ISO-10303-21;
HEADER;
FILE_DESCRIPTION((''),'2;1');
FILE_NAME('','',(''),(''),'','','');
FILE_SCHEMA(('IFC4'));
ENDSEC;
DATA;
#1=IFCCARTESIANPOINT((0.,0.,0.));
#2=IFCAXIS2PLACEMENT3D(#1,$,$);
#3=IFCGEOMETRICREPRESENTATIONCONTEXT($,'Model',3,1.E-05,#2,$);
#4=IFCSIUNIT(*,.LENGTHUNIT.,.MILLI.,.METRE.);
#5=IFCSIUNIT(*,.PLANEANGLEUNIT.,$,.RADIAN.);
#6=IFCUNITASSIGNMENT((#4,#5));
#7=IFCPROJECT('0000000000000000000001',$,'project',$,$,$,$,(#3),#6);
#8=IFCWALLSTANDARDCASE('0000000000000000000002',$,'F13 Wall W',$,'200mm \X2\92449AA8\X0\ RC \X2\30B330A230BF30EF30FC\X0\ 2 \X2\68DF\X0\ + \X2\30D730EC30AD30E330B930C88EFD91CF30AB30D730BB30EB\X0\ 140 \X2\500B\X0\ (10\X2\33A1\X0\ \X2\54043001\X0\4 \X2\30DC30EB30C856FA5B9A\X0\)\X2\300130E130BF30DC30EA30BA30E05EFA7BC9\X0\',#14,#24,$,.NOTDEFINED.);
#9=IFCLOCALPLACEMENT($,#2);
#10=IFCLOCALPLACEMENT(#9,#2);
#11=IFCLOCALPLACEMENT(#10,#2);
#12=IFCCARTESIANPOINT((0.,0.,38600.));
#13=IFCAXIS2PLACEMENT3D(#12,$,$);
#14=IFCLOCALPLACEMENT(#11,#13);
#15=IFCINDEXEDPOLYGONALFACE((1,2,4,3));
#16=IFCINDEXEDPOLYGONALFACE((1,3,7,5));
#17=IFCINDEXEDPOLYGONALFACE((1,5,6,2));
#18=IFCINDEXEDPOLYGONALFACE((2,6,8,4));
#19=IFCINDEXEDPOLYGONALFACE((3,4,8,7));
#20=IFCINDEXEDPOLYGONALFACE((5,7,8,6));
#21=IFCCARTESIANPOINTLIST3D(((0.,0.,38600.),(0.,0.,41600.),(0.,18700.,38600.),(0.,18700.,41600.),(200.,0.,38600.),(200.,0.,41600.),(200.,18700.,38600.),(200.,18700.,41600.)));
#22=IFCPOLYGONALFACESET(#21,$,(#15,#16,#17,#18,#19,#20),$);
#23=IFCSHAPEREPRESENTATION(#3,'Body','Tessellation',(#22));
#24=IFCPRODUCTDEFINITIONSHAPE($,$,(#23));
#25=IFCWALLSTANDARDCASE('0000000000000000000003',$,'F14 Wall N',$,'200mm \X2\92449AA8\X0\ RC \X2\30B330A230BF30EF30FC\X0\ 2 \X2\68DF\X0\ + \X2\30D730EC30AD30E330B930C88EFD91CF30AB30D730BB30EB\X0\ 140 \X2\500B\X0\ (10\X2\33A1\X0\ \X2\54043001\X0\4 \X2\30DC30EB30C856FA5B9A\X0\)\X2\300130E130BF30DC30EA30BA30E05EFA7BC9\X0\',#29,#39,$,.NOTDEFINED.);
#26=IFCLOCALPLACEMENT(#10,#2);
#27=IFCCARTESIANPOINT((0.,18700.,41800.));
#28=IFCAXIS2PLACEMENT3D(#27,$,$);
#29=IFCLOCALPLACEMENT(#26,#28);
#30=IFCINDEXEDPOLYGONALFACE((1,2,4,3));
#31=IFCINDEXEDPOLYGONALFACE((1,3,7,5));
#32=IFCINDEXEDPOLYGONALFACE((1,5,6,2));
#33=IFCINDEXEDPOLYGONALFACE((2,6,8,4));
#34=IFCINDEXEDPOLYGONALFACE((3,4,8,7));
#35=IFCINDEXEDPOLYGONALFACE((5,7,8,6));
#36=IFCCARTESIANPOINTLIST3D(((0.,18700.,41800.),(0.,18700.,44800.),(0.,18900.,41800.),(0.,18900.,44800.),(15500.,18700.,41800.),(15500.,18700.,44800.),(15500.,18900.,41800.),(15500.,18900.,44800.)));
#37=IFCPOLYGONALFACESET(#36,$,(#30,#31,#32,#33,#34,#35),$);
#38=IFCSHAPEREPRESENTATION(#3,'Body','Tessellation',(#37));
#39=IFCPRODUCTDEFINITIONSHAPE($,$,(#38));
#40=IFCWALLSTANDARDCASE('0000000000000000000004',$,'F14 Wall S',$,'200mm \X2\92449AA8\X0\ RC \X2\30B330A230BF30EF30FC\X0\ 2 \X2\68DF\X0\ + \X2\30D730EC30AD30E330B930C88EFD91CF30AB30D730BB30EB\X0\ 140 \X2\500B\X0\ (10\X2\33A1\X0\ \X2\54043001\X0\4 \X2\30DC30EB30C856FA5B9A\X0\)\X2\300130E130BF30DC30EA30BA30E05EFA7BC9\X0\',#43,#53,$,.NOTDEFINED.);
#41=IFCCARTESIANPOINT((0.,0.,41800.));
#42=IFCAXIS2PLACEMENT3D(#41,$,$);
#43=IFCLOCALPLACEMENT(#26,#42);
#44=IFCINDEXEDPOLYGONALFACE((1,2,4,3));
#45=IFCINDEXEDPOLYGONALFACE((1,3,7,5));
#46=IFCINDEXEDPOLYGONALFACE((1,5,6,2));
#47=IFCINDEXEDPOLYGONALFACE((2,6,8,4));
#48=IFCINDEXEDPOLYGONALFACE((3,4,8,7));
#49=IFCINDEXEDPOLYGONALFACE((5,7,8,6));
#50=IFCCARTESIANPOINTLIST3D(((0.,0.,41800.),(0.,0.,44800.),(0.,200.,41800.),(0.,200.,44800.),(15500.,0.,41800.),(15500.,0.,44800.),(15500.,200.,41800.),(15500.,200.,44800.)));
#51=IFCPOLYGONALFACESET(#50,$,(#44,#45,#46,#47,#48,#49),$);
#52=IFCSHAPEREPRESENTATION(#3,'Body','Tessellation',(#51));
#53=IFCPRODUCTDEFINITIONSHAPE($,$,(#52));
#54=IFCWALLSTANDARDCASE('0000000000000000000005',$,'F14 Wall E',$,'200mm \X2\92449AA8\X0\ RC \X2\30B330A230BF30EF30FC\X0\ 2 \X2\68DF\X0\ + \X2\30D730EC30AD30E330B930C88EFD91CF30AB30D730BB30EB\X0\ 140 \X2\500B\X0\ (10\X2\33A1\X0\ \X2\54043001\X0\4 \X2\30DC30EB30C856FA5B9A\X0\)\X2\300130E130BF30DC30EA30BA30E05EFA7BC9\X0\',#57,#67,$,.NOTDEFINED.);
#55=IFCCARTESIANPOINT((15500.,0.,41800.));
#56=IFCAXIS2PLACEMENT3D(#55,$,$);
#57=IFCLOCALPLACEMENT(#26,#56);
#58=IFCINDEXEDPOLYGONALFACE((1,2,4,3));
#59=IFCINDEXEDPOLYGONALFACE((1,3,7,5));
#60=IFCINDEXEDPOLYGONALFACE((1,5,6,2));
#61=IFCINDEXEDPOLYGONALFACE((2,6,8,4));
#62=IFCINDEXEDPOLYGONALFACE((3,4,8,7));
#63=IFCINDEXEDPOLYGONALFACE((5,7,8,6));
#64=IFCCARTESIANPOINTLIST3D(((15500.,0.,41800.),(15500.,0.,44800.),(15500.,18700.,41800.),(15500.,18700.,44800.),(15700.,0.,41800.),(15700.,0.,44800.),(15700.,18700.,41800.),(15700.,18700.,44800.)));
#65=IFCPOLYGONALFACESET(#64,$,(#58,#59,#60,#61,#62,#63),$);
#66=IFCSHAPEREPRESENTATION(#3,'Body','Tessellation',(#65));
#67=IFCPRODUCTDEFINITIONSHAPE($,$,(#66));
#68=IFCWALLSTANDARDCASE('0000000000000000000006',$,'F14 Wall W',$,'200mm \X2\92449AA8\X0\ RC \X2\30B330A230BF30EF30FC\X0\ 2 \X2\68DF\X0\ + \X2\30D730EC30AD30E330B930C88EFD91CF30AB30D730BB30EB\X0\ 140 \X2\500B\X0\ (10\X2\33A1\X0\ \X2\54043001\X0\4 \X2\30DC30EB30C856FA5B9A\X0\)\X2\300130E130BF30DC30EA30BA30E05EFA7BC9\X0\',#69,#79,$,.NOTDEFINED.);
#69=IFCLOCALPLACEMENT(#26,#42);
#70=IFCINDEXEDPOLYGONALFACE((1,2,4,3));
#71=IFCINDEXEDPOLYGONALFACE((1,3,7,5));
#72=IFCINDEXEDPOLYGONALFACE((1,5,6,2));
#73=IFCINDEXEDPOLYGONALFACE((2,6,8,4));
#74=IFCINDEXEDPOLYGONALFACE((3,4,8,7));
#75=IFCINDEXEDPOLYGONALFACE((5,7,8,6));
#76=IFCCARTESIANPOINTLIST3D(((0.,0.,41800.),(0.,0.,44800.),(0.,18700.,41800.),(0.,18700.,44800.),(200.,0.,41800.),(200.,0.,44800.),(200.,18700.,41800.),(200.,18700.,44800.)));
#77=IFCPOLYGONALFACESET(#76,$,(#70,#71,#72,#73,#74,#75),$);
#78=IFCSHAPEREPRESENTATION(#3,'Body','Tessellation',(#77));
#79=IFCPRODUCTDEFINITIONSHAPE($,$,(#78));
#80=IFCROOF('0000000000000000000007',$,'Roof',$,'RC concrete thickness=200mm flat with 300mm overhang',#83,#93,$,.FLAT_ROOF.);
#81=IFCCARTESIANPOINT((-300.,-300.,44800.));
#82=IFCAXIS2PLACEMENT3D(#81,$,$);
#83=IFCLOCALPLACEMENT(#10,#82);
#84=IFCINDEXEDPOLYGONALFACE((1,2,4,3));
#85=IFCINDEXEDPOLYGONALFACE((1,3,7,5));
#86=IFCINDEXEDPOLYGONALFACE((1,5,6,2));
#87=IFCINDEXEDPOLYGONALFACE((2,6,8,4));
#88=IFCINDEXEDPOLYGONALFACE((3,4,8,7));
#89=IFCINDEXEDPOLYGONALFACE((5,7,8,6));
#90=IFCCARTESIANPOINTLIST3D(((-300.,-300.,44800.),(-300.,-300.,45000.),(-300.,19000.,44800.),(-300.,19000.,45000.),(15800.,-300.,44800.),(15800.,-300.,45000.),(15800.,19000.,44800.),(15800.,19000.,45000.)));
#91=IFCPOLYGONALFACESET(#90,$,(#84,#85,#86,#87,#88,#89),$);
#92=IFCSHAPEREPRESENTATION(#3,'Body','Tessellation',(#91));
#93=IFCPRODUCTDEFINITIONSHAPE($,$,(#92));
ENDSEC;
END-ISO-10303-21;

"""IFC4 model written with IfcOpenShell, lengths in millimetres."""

from ifc_helpers import new_model, si_unit, frame, frame_2d, origin, place, context, project, rectangle, extrude, element, save


model = new_model("IFC4")

# Units and contexts
model_context = context("Model", 3, precision=1e-05, world=origin())
ifc_project = project(units=[si_unit("LENGTHUNIT", "METRE", prefix="MILLI"), si_unit("PLANEANGLEUNIT", "RADIAN")], contexts=[model_context])

# Shared definitions
placement_1 = place(None, origin())
placement_2 = place(placement_1, origin())
placement_3 = place(placement_2, origin())
placement_4 = place(placement_2, origin())

# Walls
wall_1_placement = place(placement_3, frame((0.0, 0.0, 38600.0)))
element("IfcWallStandardCase", 1, at=wall_1_placement, Name="F13 Wall W", ObjectType="200mm 鉄骨 RC コアタワー 2 棟 + プレキャスト軽量カプセル 140 個 (10㎡ 各、4 ボルト固定)、メタボリズム建築", PredefinedType="NOTDEFINED", context=model_context, shape_type="SweptSolid", body=[
    extrude(rectangle(XDim=200.0, YDim=18700.0, at=frame_2d((100.0, 9350.0))), frame((0.0, 0.0, 38600.0)), (0.0, 0.0, 1.0), 3000.0),
])
wall_2_placement = place(placement_4, frame((0.0, 18700.0, 41800.0)))
element("IfcWallStandardCase", 2, at=wall_2_placement, Name="F14 Wall N", ObjectType="200mm 鉄骨 RC コアタワー 2 棟 + プレキャスト軽量カプセル 140 個 (10㎡ 各、4 ボルト固定)、メタボリズム建築", PredefinedType="NOTDEFINED", context=model_context, shape_type="SweptSolid", body=[
    extrude(rectangle(XDim=15500.0, YDim=200.0, at=frame_2d((7750.0, 100.0))), frame((0.0, 18700.0, 41800.0)), (0.0, 0.0, 1.0), 3000.0),
])
wall_3_placement = place(placement_4, frame((0.0, 0.0, 41800.0)))
element("IfcWallStandardCase", 3, at=wall_3_placement, Name="F14 Wall S", ObjectType="200mm 鉄骨 RC コアタワー 2 棟 + プレキャスト軽量カプセル 140 個 (10㎡ 各、4 ボルト固定)、メタボリズム建築", PredefinedType="NOTDEFINED", context=model_context, shape_type="SweptSolid", body=[
    extrude(rectangle(XDim=15500.0, YDim=200.0, at=frame_2d((7750.0, 100.0))), frame((0.0, 0.0, 41800.0)), (0.0, 0.0, 1.0), 3000.0),
])
wall_4_placement = place(placement_4, frame((15500.0, 0.0, 41800.0)))
element("IfcWallStandardCase", 4, at=wall_4_placement, Name="F14 Wall E", ObjectType="200mm 鉄骨 RC コアタワー 2 棟 + プレキャスト軽量カプセル 140 個 (10㎡ 各、4 ボルト固定)、メタボリズム建築", PredefinedType="NOTDEFINED", context=model_context, shape_type="SweptSolid", body=[
    extrude(rectangle(XDim=200.0, YDim=18700.0, at=frame_2d((100.0, 9350.0))), frame((15500.0, 0.0, 41800.0)), (0.0, 0.0, 1.0), 3000.0),
])
wall_5_placement = place(placement_4, frame((0.0, 0.0, 41800.0)))
element("IfcWallStandardCase", 5, at=wall_5_placement, Name="F14 Wall W", ObjectType="200mm 鉄骨 RC コアタワー 2 棟 + プレキャスト軽量カプセル 140 個 (10㎡ 各、4 ボルト固定)、メタボリズム建築", PredefinedType="NOTDEFINED", context=model_context, shape_type="SweptSolid", body=[
    extrude(rectangle(XDim=200.0, YDim=18700.0, at=frame_2d((100.0, 9350.0))), frame((0.0, 0.0, 41800.0)), (0.0, 0.0, 1.0), 3000.0),
])

# Roof
roof_placement = place(placement_2, frame((-300.0, -300.0, 44800.0)))
element("IfcRoof", 6, at=roof_placement, Name="Roof", ObjectType="RC concrete thickness=200mm flat with 300mm overhang", PredefinedType="FLAT_ROOF", context=model_context, shape_type="SweptSolid", body=[
    extrude(rectangle(XDim=16100.0, YDim=19300.0, at=frame_2d((8050.0, 9650.0))), frame((-300.0, -300.0, 44800.0)), (0.0, 0.0, 1.0), 200.0),
])

save(model, "model.ifc")
